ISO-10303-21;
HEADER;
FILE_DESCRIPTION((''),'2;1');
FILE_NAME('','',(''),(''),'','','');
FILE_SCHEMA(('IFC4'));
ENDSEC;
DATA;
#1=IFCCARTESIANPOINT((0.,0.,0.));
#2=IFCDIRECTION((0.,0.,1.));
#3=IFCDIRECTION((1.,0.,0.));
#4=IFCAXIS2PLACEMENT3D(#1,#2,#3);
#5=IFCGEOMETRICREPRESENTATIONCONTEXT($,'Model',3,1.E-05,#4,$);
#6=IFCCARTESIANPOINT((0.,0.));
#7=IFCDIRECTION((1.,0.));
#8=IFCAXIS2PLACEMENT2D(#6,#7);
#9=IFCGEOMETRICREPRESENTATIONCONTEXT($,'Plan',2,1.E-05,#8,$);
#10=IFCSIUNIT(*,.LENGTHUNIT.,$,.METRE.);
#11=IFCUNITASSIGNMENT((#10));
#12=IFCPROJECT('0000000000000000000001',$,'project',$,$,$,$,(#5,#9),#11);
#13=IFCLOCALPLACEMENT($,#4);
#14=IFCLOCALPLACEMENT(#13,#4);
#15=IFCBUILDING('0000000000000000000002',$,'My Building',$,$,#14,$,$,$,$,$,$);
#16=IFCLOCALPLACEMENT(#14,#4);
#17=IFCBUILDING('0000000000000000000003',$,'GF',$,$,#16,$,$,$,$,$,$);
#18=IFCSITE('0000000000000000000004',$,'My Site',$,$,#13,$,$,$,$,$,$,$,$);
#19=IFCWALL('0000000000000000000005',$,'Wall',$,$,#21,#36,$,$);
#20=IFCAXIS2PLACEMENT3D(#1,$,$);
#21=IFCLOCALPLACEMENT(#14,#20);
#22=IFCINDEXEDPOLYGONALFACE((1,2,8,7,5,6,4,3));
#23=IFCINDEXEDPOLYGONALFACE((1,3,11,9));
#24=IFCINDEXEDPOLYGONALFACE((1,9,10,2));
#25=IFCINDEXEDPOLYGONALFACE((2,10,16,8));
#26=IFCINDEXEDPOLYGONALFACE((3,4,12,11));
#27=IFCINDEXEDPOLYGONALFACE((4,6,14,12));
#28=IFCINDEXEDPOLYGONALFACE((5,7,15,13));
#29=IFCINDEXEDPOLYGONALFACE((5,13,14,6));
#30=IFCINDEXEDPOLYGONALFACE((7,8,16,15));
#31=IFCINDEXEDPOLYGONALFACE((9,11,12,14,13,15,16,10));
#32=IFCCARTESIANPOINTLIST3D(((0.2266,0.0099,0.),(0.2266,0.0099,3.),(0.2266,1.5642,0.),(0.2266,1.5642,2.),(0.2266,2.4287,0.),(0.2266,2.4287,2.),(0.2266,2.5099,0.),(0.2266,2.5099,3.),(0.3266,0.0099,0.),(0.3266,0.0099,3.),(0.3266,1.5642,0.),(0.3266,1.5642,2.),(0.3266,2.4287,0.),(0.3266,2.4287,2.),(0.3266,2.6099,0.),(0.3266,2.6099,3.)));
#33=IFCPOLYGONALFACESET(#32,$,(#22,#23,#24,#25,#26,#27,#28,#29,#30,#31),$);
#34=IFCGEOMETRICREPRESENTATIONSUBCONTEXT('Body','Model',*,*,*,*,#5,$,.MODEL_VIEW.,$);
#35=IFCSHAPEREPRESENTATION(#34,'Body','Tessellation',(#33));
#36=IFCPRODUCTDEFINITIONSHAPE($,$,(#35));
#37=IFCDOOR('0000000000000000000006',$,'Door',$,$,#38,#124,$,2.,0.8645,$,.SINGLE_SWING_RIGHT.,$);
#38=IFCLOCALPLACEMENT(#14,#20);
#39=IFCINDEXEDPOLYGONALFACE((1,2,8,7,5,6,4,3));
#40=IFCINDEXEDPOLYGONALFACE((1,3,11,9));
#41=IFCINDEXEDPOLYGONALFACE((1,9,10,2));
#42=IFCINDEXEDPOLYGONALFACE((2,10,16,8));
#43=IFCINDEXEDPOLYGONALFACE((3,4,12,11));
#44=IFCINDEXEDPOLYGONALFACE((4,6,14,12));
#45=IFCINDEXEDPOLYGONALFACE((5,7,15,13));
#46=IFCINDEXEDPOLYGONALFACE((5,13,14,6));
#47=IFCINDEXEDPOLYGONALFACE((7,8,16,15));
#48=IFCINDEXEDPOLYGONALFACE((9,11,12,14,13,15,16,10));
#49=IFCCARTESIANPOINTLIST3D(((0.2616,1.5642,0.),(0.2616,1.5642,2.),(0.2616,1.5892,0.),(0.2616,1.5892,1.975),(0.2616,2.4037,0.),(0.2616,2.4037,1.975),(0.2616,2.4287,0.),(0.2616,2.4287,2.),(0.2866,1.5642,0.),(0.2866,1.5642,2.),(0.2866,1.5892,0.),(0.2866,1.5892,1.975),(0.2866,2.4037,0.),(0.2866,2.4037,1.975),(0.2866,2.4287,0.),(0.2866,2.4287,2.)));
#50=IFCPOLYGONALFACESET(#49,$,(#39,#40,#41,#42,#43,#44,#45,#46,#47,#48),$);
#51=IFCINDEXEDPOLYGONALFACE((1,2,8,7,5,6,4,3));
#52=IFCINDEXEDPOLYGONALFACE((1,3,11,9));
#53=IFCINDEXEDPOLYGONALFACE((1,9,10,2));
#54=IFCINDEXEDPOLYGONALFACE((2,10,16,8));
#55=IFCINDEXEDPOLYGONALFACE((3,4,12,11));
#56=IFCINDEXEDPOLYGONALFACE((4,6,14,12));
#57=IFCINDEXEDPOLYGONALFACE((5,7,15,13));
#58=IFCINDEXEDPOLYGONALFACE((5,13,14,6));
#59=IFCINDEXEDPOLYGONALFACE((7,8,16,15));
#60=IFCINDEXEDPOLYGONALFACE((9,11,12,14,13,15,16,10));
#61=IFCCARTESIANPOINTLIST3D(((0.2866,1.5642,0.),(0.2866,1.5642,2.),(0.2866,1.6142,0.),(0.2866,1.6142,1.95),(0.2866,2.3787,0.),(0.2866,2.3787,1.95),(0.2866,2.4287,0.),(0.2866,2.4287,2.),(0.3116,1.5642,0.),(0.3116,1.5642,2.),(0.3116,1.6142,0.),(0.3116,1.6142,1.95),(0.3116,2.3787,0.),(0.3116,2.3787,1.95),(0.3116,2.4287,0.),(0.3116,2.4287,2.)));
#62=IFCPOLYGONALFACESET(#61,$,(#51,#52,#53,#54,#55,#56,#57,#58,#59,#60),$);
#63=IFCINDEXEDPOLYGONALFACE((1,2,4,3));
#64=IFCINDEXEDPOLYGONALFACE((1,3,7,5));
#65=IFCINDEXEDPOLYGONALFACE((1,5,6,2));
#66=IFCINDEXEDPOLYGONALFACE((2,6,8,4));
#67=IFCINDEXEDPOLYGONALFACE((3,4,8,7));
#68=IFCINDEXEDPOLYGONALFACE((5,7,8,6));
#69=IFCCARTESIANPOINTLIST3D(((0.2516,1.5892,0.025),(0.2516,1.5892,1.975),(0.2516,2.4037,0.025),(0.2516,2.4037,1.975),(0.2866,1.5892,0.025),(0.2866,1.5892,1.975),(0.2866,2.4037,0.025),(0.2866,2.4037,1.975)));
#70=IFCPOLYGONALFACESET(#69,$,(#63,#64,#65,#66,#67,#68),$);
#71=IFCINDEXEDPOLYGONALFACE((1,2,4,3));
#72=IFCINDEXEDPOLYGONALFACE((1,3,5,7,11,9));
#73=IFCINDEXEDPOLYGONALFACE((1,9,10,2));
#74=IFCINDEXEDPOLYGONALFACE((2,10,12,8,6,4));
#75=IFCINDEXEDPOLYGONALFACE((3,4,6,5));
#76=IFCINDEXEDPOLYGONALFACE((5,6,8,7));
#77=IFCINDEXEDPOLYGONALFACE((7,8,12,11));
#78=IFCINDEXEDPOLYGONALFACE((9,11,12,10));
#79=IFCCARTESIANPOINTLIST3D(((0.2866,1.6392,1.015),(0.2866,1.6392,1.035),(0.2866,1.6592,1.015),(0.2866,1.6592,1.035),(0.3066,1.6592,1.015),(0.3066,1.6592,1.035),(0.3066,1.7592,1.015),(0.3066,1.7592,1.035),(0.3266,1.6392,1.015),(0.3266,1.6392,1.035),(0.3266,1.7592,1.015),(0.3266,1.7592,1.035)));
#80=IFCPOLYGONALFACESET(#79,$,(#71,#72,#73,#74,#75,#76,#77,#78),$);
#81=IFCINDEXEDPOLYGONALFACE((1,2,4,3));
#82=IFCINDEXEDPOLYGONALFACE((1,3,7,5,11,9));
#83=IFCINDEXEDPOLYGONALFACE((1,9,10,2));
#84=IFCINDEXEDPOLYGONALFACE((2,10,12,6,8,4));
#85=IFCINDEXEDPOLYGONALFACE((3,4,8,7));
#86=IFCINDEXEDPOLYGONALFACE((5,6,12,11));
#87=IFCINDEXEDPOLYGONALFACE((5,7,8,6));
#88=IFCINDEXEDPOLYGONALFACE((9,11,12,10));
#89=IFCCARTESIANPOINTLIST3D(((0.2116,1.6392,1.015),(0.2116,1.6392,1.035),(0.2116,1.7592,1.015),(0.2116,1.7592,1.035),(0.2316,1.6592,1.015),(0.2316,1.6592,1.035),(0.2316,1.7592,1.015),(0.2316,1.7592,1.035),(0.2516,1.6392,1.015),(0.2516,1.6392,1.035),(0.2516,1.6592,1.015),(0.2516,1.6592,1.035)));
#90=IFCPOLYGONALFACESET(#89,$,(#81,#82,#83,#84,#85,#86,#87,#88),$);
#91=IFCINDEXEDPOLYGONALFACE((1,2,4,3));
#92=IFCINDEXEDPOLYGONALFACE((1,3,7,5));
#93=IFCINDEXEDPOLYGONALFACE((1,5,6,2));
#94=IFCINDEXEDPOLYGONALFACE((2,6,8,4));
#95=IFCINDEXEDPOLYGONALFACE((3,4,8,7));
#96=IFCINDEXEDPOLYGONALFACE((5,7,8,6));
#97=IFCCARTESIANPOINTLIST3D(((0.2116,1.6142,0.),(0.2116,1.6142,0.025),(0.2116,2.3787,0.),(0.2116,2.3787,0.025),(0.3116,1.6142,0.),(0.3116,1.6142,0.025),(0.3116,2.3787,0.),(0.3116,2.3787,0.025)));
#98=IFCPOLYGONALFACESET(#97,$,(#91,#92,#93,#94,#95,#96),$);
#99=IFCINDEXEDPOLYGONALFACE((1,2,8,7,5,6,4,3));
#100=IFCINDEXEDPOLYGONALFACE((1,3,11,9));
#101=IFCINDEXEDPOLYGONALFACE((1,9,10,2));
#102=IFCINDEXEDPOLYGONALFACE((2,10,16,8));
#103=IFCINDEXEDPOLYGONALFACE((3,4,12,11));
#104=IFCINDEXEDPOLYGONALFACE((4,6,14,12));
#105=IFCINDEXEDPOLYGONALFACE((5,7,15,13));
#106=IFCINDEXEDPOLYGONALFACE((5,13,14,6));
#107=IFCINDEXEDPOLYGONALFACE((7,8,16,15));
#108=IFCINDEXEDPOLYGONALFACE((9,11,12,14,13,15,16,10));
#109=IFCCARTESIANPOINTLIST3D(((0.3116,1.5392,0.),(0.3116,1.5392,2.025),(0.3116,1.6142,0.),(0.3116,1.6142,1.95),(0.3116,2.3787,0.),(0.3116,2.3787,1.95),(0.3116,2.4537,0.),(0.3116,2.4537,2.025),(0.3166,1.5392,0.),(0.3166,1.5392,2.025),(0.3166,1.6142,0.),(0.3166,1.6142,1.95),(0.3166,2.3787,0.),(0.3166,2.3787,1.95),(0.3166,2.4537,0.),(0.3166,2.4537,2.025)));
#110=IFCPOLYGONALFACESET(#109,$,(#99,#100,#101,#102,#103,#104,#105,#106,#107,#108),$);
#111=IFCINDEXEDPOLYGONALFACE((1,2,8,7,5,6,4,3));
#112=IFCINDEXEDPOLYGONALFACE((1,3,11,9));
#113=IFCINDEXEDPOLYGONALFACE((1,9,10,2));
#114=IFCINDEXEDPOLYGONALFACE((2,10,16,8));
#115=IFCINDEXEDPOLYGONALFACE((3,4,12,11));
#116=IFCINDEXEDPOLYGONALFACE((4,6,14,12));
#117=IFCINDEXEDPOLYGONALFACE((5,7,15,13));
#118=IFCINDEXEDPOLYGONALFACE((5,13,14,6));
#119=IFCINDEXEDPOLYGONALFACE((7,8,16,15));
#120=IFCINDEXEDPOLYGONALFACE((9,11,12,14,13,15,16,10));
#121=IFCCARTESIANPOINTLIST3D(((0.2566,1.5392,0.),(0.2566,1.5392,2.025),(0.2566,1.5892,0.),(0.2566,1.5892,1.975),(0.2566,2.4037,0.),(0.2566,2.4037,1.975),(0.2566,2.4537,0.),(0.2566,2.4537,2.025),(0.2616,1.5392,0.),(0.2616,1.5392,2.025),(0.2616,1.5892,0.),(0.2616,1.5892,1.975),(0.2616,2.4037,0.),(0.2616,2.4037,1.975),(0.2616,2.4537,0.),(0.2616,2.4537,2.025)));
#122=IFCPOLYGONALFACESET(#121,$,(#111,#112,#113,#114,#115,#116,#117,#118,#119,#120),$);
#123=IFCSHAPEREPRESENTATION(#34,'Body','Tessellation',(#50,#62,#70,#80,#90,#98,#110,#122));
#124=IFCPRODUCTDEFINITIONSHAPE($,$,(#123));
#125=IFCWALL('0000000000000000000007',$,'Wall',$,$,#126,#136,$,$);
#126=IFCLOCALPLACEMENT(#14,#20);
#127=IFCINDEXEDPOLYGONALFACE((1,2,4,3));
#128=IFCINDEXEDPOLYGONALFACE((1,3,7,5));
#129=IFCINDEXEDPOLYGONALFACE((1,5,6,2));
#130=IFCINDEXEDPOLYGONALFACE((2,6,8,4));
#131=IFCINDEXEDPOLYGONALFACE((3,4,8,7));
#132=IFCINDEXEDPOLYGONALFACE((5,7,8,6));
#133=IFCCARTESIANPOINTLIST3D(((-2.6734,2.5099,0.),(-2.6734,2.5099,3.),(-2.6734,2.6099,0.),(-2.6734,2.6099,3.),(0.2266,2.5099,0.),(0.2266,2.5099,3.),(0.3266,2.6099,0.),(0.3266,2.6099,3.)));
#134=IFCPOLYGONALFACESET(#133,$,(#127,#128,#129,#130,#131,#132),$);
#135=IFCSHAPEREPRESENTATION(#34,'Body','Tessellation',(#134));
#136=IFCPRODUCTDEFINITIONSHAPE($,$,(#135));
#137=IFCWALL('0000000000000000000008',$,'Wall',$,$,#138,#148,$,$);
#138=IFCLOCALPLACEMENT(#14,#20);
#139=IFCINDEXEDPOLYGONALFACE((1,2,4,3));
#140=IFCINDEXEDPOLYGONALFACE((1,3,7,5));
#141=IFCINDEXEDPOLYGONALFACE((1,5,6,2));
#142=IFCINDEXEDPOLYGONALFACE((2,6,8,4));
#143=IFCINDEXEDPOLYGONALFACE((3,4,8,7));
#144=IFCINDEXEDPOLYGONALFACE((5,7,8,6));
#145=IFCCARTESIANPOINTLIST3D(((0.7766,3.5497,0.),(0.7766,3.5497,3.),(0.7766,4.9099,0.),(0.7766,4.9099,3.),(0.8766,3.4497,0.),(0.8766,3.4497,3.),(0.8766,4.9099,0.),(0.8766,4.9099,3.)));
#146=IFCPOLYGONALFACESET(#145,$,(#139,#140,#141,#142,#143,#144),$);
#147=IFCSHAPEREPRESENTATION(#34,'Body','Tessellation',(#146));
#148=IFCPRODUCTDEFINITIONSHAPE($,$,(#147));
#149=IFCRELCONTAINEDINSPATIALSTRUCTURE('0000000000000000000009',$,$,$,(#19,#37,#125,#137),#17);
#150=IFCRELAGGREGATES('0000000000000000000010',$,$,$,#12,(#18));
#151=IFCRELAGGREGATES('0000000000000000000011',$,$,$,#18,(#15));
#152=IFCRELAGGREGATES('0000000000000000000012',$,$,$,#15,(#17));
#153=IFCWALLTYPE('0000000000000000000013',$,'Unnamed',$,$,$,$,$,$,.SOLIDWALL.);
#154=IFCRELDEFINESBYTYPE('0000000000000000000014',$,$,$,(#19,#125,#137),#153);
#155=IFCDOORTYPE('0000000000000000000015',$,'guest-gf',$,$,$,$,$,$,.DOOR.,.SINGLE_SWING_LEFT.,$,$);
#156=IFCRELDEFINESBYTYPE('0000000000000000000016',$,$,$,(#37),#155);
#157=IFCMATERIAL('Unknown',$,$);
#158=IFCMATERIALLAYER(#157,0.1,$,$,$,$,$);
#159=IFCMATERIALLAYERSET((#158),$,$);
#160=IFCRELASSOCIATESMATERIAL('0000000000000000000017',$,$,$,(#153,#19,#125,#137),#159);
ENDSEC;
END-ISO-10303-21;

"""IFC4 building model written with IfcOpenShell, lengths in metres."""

from ifc_helpers import new_model, entity, si_unit, frame, origin_with_axes, origin_2d_with_axis, place, context, subcontext, project, spatial, line, indexed_curve, outline, extrude, shape, source, transform, mapped, material, layer, layer_set, layer_usage, type_object, type_shapes, element, fill, save


model = new_model("IFC4")

# Units and contexts
model_context = context("Model", 3, precision=1e-05, world=origin_with_axes())
plan_context = context("Plan", 2, precision=1e-05, world=origin_2d_with_axis())
body_context_1 = subcontext(model_context, "Body", "Model", "MODEL_VIEW")
body_context_2 = subcontext(plan_context, "Body", "Plan", "PLAN_VIEW")
ifc_project = project(units=[si_unit("LENGTHUNIT", "METRE")], contexts=[model_context, plan_context])

# Site, buildings
site_placement = place(None, origin_with_axes())
site = spatial("IfcSite", under=ifc_project, at=site_placement, Name="My Site")
building_1_placement = place(site_placement, origin_with_axes())
building_1 = spatial("IfcBuilding", under=site, at=building_1_placement, Name="My Building")
building_2_placement = place(building_1_placement, origin_with_axes())
building_2 = spatial("IfcBuilding", under=building_1, at=building_2_placement, Name="GF")

# Shared definitions
ifc_material = material(Name="Unknown")

# Shared definitions
ifc_layer_1 = layer(ifc_material, 0.1)
ifc_layer_set_1 = layer_set([ifc_layer_1])
wall_type = type_object("IfcWallType", Name="Unnamed", PredefinedType="SOLIDWALL", material=ifc_layer_set_1)

# Wall, opening, door
ifc_layer_usage_1 = layer_usage(ifc_layer_set_1, "AXIS2", "POSITIVE", 0.0)
wall_1_placement = place(building_2_placement, frame((0.3266, 0.0099, 0.0), z_axis=(0.0, 0.0, 1.0), x_axis=(0.0, 1.0, 0.0)))
wall_1 = element("IfcWall", 1, at=wall_1_placement, inside=building_2, type_object=wall_type, material=ifc_layer_usage_1, Name="Wall", context=body_context_1, shape_type="SweptSolid", body=[
    extrude(outline(indexed_curve([(0.0, 0.0), (0.0, 0.1), (2.5, 0.1), (2.6, 0.0)], segments=[line(1, 2, 3, 4, 1)])), origin_with_axes(), (0.0, 0.0, 1.0), 3.0),
])
shared_shape_1 = source(origin_with_axes(), body_context_1, "Body", "SweptSolid", [
    extrude(outline(indexed_curve([(0.0, 0.0), (0.8645, 0.0), (0.8645, 2.0), (0.0, 2.0)], segments=[line(1, 2, 3, 4, 1)])), frame((0.0, -0.6, 0.0), z_axis=(0.0, -1.0, 0.0), x_axis=(1.0, 0.0, 0.0)), (0.0, 0.0, -1.0), 1.2),
])
opening_1_placement = place(wall_1_placement, frame((1.5543, 0.015, 0.0), z_axis=(0.0, 0.0, 1.0), x_axis=(1.0, 0.0, 0.0)))
opening_1 = element("IfcOpeningElement", 2, at=opening_1_placement, cuts=wall_1, PredefinedType="OPENING", context=body_context_1, shape_type="MappedRepresentation", body=[
    mapped(shared_shape_1, transform((0.0, 0.0, 0.0), x_axis=(1.0, 0.0, 0.0), y_axis=(0.0, 1.0, 0.0), z_axis=(0.0, 0.0, 1.0), scale=1.0)),
])
door_type_1 = type_object("IfcDoorType", Name="guest-gf", OperationType="SINGLE_SWING_LEFT", PredefinedType="DOOR")
shared_shape_2 = source(origin_with_axes(), body_context_1, "Body", "SweptSolid", [
    extrude(outline(indexed_curve([(0.0, 0.0), (0.0, 2.0), (0.8645, 2.0), (0.8645, 0.0), (0.8395, 0.0), (0.8395, 1.975), (0.025, 1.975), (0.025, 0.0)], segments=[line(1, 2, 3, 4, 5, 6, 7, 8, 1)])), frame((0.0, 0.025, 0.0), z_axis=(0.0, -1.0, 0.0), x_axis=(1.0, 0.0, 0.0)), (0.0, 0.0, -1.0), 0.025),
    extrude(outline(indexed_curve([(0.0, 0.0), (0.0, 2.0), (0.8645, 2.0), (0.8645, 0.0), (0.8145, 0.0), (0.8145, 1.95), (0.05, 1.95), (0.05, 0.0)], segments=[line(1, 2, 3, 4, 5, 6, 7, 8, 1)])), frame((0.0, 0.0, 0.0), z_axis=(0.0, -1.0, 0.0), x_axis=(1.0, 0.0, 0.0)), (0.0, 0.0, -1.0), 0.025),
    extrude(outline(indexed_curve([(0.0, 0.0), (0.8145, 0.0), (0.8145, 0.035), (0.0, 0.035)], segments=[line(1, 2, 3, 4, 1)])), frame((0.025, 0.025, 0.025), z_axis=(0.0, 0.0, 1.0), x_axis=(1.0, 0.0, 0.0)), (0.0, 0.0, 1.0), 1.95),
    extrude(outline(indexed_curve([(0.0, 0.0), (0.0, -0.04), (0.12, -0.04), (0.12, -0.02), (0.02, -0.02), (0.02, 0.0)], segments=[line(1, 2, 3, 4, 5, 6, 1)])), frame((0.075, 0.025, 1.015), z_axis=(0.0, 0.0, 1.0), x_axis=(1.0, 0.0, 0.0)), (0.0, 0.0, 1.0), 0.02),
    extrude(outline(indexed_curve([(0.0, 0.0), (0.0, 0.04), (0.12, 0.04), (0.12, 0.02), (0.02, 0.02), (0.02, 0.0)], segments=[line(1, 2, 3, 4, 5, 6, 1)])), frame((0.075, 0.06, 1.015), z_axis=(0.0, 0.0, 1.0), x_axis=(1.0, 0.0, 0.0)), (0.0, 0.0, 1.0), 0.02),
    extrude(outline(indexed_curve([(0.0, 0.0), (0.7645, 0.0), (0.7645, 0.1), (0.0, 0.1)], segments=[line(1, 2, 3, 4, 1)])), frame((0.05, 0.0, 0.0), z_axis=(0.0, 0.0, 1.0), x_axis=(1.0, 0.0, 0.0)), (0.0, 0.0, 1.0), 0.025),
    extrude(outline(indexed_curve([(0.0, 0.0), (0.0, 2.025), (0.9145, 2.025), (0.9145, 0.0), (0.8395, 0.0), (0.8395, 1.95), (0.075, 1.95), (0.075, 0.0)], segments=[line(1, 2, 3, 4, 5, 6, 7, 8, 1)])), frame((-0.025, -0.005, 0.0), z_axis=(0.0, -1.0, 0.0), x_axis=(1.0, 0.0, 0.0)), (0.0, 0.0, -1.0), 0.005),
    extrude(outline(indexed_curve([(0.0, 0.0), (0.0, 2.025), (0.9145, 2.025), (0.9145, 0.0), (0.8645, 0.0), (0.8645, 1.975), (0.05, 1.975), (0.05, 0.0)], segments=[line(1, 2, 3, 4, 5, 6, 7, 8, 1)])), frame((-0.025, 0.05, 0.0), z_axis=(0.0, -1.0, 0.0), x_axis=(1.0, 0.0, 0.0)), (0.0, 0.0, -1.0), 0.005),
])
shared_shape_3 = source(origin_with_axes(), body_context_2, "Body", "Curve2D", [
    entity("IfcIndexedPolyCurve", entity("IfcCartesianPointList2D", [[0.0, 0.0], [0.0, 0.05], [0.025, 0.05], [0.025, 0.025], [0.05, 0.025], [0.05, 0.0]]), [entity("IfcLineIndex", [1, 2, 3, 4, 5, 6, 1])]),
    entity("IfcIndexedPolyCurve", entity("IfcCartesianPointList2D", [[0.8645, 0.0], [0.8645, 0.05], [0.8395, 0.05], [0.8395, 0.025], [0.8145, 0.025], [0.8145, 0.0]]), [entity("IfcLineIndex", [1, 2, 3, 4, 5, 6, 1])]),
    entity("IfcTrimmedCurve", entity("IfcEllipse", entity("IfcAxis2Placement2D", entity("IfcCartesianPoint", [0.8045, 0.05]), entity("IfcDirection", [1.0, 0.0])), 0.7795, 0.8145), [entity("IfcCartesianPoint", [0.8045, 0.8645])], [entity("IfcCartesianPoint", [0.025, 0.05])], True, "CARTESIAN"),
    entity("IfcIndexedPolyCurve", entity("IfcCartesianPointList2D", [[0.8395, 0.05], [0.8045, 0.05], [0.8045, 0.8645], [0.8395, 0.8645]]), [entity("IfcLineIndex", [1, 2, 3, 4, 1])]),
])
type_shapes(door_type_1, [shared_shape_2, shared_shape_3])
door_1_placement = place(opening_1_placement, frame((0.0, 0.0, 0.0), z_axis=(0.0, 0.0, 1.0), x_axis=(1.0, 0.0, 0.0)))
door_1 = element("IfcDoor", 3, at=door_1_placement, inside=building_2, type_object=door_type_1, Name="Door", OperationType="SINGLE_SWING_RIGHT", OverallHeight=2.0, OverallWidth=0.8645, shapes=[
    shape(body_context_1, "Body", "MappedRepresentation", [mapped(shared_shape_2, transform((0.0, 0.0, 0.0), x_axis=(1.0, 0.0, 0.0), y_axis=(0.0, 1.0, 0.0), z_axis=(0.0, 0.0, 1.0), scale=1.0))]),
    shape(body_context_2, "Body", "MappedRepresentation", [mapped(shared_shape_3, transform((0.0, 0.0, 0.0), x_axis=(1.0, 0.0, 0.0), y_axis=(0.0, 1.0, 0.0), z_axis=(0.0, 0.0, 1.0), scale=1.0))]),
])
fill(opening_1, door_1)

# Walls
ifc_layer_usage_2 = layer_usage(ifc_layer_set_1, "AXIS2", "POSITIVE", 0.0)
wall_2_placement = place(building_2_placement, frame((0.3266, 2.6099, 0.0), z_axis=(0.0, 0.0, 1.0), x_axis=(-1.0, 0.0, 0.0)))
element("IfcWall", 4, at=wall_2_placement, inside=building_2, type_object=wall_type, material=ifc_layer_usage_2, Name="Wall", context=body_context_1, shape_type="SweptSolid", body=[
    extrude(outline(indexed_curve([(0.0, 0.0), (0.1, 0.1), (3.0, 0.1), (3.0, 0.0)], segments=[line(1, 2, 3, 4, 1)])), origin_with_axes(), (0.0, 0.0, 1.0), 3.0),
])
ifc_layer_usage_3 = layer_usage(ifc_layer_set_1, "AXIS2", "POSITIVE", 0.0)
wall_3_placement = place(building_2_placement, frame((0.8766, 3.5497, 0.0), z_axis=(0.0, 0.0, 1.0), x_axis=(0.0, 1.0, 0.0)))
element("IfcWall", 5, at=wall_3_placement, inside=building_2, type_object=wall_type, material=ifc_layer_usage_3, Name="Wall", context=body_context_1, shape_type="SweptSolid", body=[
    extrude(outline(indexed_curve([(-0.1, 0.0), (0.0, 0.1), (1.3602, 0.1), (1.3602, 0.0)], segments=[line(1, 2, 3, 4, 1)])), origin_with_axes(), (0.0, 0.0, 1.0), 3.0),
])

save(model, "model.ifc")
